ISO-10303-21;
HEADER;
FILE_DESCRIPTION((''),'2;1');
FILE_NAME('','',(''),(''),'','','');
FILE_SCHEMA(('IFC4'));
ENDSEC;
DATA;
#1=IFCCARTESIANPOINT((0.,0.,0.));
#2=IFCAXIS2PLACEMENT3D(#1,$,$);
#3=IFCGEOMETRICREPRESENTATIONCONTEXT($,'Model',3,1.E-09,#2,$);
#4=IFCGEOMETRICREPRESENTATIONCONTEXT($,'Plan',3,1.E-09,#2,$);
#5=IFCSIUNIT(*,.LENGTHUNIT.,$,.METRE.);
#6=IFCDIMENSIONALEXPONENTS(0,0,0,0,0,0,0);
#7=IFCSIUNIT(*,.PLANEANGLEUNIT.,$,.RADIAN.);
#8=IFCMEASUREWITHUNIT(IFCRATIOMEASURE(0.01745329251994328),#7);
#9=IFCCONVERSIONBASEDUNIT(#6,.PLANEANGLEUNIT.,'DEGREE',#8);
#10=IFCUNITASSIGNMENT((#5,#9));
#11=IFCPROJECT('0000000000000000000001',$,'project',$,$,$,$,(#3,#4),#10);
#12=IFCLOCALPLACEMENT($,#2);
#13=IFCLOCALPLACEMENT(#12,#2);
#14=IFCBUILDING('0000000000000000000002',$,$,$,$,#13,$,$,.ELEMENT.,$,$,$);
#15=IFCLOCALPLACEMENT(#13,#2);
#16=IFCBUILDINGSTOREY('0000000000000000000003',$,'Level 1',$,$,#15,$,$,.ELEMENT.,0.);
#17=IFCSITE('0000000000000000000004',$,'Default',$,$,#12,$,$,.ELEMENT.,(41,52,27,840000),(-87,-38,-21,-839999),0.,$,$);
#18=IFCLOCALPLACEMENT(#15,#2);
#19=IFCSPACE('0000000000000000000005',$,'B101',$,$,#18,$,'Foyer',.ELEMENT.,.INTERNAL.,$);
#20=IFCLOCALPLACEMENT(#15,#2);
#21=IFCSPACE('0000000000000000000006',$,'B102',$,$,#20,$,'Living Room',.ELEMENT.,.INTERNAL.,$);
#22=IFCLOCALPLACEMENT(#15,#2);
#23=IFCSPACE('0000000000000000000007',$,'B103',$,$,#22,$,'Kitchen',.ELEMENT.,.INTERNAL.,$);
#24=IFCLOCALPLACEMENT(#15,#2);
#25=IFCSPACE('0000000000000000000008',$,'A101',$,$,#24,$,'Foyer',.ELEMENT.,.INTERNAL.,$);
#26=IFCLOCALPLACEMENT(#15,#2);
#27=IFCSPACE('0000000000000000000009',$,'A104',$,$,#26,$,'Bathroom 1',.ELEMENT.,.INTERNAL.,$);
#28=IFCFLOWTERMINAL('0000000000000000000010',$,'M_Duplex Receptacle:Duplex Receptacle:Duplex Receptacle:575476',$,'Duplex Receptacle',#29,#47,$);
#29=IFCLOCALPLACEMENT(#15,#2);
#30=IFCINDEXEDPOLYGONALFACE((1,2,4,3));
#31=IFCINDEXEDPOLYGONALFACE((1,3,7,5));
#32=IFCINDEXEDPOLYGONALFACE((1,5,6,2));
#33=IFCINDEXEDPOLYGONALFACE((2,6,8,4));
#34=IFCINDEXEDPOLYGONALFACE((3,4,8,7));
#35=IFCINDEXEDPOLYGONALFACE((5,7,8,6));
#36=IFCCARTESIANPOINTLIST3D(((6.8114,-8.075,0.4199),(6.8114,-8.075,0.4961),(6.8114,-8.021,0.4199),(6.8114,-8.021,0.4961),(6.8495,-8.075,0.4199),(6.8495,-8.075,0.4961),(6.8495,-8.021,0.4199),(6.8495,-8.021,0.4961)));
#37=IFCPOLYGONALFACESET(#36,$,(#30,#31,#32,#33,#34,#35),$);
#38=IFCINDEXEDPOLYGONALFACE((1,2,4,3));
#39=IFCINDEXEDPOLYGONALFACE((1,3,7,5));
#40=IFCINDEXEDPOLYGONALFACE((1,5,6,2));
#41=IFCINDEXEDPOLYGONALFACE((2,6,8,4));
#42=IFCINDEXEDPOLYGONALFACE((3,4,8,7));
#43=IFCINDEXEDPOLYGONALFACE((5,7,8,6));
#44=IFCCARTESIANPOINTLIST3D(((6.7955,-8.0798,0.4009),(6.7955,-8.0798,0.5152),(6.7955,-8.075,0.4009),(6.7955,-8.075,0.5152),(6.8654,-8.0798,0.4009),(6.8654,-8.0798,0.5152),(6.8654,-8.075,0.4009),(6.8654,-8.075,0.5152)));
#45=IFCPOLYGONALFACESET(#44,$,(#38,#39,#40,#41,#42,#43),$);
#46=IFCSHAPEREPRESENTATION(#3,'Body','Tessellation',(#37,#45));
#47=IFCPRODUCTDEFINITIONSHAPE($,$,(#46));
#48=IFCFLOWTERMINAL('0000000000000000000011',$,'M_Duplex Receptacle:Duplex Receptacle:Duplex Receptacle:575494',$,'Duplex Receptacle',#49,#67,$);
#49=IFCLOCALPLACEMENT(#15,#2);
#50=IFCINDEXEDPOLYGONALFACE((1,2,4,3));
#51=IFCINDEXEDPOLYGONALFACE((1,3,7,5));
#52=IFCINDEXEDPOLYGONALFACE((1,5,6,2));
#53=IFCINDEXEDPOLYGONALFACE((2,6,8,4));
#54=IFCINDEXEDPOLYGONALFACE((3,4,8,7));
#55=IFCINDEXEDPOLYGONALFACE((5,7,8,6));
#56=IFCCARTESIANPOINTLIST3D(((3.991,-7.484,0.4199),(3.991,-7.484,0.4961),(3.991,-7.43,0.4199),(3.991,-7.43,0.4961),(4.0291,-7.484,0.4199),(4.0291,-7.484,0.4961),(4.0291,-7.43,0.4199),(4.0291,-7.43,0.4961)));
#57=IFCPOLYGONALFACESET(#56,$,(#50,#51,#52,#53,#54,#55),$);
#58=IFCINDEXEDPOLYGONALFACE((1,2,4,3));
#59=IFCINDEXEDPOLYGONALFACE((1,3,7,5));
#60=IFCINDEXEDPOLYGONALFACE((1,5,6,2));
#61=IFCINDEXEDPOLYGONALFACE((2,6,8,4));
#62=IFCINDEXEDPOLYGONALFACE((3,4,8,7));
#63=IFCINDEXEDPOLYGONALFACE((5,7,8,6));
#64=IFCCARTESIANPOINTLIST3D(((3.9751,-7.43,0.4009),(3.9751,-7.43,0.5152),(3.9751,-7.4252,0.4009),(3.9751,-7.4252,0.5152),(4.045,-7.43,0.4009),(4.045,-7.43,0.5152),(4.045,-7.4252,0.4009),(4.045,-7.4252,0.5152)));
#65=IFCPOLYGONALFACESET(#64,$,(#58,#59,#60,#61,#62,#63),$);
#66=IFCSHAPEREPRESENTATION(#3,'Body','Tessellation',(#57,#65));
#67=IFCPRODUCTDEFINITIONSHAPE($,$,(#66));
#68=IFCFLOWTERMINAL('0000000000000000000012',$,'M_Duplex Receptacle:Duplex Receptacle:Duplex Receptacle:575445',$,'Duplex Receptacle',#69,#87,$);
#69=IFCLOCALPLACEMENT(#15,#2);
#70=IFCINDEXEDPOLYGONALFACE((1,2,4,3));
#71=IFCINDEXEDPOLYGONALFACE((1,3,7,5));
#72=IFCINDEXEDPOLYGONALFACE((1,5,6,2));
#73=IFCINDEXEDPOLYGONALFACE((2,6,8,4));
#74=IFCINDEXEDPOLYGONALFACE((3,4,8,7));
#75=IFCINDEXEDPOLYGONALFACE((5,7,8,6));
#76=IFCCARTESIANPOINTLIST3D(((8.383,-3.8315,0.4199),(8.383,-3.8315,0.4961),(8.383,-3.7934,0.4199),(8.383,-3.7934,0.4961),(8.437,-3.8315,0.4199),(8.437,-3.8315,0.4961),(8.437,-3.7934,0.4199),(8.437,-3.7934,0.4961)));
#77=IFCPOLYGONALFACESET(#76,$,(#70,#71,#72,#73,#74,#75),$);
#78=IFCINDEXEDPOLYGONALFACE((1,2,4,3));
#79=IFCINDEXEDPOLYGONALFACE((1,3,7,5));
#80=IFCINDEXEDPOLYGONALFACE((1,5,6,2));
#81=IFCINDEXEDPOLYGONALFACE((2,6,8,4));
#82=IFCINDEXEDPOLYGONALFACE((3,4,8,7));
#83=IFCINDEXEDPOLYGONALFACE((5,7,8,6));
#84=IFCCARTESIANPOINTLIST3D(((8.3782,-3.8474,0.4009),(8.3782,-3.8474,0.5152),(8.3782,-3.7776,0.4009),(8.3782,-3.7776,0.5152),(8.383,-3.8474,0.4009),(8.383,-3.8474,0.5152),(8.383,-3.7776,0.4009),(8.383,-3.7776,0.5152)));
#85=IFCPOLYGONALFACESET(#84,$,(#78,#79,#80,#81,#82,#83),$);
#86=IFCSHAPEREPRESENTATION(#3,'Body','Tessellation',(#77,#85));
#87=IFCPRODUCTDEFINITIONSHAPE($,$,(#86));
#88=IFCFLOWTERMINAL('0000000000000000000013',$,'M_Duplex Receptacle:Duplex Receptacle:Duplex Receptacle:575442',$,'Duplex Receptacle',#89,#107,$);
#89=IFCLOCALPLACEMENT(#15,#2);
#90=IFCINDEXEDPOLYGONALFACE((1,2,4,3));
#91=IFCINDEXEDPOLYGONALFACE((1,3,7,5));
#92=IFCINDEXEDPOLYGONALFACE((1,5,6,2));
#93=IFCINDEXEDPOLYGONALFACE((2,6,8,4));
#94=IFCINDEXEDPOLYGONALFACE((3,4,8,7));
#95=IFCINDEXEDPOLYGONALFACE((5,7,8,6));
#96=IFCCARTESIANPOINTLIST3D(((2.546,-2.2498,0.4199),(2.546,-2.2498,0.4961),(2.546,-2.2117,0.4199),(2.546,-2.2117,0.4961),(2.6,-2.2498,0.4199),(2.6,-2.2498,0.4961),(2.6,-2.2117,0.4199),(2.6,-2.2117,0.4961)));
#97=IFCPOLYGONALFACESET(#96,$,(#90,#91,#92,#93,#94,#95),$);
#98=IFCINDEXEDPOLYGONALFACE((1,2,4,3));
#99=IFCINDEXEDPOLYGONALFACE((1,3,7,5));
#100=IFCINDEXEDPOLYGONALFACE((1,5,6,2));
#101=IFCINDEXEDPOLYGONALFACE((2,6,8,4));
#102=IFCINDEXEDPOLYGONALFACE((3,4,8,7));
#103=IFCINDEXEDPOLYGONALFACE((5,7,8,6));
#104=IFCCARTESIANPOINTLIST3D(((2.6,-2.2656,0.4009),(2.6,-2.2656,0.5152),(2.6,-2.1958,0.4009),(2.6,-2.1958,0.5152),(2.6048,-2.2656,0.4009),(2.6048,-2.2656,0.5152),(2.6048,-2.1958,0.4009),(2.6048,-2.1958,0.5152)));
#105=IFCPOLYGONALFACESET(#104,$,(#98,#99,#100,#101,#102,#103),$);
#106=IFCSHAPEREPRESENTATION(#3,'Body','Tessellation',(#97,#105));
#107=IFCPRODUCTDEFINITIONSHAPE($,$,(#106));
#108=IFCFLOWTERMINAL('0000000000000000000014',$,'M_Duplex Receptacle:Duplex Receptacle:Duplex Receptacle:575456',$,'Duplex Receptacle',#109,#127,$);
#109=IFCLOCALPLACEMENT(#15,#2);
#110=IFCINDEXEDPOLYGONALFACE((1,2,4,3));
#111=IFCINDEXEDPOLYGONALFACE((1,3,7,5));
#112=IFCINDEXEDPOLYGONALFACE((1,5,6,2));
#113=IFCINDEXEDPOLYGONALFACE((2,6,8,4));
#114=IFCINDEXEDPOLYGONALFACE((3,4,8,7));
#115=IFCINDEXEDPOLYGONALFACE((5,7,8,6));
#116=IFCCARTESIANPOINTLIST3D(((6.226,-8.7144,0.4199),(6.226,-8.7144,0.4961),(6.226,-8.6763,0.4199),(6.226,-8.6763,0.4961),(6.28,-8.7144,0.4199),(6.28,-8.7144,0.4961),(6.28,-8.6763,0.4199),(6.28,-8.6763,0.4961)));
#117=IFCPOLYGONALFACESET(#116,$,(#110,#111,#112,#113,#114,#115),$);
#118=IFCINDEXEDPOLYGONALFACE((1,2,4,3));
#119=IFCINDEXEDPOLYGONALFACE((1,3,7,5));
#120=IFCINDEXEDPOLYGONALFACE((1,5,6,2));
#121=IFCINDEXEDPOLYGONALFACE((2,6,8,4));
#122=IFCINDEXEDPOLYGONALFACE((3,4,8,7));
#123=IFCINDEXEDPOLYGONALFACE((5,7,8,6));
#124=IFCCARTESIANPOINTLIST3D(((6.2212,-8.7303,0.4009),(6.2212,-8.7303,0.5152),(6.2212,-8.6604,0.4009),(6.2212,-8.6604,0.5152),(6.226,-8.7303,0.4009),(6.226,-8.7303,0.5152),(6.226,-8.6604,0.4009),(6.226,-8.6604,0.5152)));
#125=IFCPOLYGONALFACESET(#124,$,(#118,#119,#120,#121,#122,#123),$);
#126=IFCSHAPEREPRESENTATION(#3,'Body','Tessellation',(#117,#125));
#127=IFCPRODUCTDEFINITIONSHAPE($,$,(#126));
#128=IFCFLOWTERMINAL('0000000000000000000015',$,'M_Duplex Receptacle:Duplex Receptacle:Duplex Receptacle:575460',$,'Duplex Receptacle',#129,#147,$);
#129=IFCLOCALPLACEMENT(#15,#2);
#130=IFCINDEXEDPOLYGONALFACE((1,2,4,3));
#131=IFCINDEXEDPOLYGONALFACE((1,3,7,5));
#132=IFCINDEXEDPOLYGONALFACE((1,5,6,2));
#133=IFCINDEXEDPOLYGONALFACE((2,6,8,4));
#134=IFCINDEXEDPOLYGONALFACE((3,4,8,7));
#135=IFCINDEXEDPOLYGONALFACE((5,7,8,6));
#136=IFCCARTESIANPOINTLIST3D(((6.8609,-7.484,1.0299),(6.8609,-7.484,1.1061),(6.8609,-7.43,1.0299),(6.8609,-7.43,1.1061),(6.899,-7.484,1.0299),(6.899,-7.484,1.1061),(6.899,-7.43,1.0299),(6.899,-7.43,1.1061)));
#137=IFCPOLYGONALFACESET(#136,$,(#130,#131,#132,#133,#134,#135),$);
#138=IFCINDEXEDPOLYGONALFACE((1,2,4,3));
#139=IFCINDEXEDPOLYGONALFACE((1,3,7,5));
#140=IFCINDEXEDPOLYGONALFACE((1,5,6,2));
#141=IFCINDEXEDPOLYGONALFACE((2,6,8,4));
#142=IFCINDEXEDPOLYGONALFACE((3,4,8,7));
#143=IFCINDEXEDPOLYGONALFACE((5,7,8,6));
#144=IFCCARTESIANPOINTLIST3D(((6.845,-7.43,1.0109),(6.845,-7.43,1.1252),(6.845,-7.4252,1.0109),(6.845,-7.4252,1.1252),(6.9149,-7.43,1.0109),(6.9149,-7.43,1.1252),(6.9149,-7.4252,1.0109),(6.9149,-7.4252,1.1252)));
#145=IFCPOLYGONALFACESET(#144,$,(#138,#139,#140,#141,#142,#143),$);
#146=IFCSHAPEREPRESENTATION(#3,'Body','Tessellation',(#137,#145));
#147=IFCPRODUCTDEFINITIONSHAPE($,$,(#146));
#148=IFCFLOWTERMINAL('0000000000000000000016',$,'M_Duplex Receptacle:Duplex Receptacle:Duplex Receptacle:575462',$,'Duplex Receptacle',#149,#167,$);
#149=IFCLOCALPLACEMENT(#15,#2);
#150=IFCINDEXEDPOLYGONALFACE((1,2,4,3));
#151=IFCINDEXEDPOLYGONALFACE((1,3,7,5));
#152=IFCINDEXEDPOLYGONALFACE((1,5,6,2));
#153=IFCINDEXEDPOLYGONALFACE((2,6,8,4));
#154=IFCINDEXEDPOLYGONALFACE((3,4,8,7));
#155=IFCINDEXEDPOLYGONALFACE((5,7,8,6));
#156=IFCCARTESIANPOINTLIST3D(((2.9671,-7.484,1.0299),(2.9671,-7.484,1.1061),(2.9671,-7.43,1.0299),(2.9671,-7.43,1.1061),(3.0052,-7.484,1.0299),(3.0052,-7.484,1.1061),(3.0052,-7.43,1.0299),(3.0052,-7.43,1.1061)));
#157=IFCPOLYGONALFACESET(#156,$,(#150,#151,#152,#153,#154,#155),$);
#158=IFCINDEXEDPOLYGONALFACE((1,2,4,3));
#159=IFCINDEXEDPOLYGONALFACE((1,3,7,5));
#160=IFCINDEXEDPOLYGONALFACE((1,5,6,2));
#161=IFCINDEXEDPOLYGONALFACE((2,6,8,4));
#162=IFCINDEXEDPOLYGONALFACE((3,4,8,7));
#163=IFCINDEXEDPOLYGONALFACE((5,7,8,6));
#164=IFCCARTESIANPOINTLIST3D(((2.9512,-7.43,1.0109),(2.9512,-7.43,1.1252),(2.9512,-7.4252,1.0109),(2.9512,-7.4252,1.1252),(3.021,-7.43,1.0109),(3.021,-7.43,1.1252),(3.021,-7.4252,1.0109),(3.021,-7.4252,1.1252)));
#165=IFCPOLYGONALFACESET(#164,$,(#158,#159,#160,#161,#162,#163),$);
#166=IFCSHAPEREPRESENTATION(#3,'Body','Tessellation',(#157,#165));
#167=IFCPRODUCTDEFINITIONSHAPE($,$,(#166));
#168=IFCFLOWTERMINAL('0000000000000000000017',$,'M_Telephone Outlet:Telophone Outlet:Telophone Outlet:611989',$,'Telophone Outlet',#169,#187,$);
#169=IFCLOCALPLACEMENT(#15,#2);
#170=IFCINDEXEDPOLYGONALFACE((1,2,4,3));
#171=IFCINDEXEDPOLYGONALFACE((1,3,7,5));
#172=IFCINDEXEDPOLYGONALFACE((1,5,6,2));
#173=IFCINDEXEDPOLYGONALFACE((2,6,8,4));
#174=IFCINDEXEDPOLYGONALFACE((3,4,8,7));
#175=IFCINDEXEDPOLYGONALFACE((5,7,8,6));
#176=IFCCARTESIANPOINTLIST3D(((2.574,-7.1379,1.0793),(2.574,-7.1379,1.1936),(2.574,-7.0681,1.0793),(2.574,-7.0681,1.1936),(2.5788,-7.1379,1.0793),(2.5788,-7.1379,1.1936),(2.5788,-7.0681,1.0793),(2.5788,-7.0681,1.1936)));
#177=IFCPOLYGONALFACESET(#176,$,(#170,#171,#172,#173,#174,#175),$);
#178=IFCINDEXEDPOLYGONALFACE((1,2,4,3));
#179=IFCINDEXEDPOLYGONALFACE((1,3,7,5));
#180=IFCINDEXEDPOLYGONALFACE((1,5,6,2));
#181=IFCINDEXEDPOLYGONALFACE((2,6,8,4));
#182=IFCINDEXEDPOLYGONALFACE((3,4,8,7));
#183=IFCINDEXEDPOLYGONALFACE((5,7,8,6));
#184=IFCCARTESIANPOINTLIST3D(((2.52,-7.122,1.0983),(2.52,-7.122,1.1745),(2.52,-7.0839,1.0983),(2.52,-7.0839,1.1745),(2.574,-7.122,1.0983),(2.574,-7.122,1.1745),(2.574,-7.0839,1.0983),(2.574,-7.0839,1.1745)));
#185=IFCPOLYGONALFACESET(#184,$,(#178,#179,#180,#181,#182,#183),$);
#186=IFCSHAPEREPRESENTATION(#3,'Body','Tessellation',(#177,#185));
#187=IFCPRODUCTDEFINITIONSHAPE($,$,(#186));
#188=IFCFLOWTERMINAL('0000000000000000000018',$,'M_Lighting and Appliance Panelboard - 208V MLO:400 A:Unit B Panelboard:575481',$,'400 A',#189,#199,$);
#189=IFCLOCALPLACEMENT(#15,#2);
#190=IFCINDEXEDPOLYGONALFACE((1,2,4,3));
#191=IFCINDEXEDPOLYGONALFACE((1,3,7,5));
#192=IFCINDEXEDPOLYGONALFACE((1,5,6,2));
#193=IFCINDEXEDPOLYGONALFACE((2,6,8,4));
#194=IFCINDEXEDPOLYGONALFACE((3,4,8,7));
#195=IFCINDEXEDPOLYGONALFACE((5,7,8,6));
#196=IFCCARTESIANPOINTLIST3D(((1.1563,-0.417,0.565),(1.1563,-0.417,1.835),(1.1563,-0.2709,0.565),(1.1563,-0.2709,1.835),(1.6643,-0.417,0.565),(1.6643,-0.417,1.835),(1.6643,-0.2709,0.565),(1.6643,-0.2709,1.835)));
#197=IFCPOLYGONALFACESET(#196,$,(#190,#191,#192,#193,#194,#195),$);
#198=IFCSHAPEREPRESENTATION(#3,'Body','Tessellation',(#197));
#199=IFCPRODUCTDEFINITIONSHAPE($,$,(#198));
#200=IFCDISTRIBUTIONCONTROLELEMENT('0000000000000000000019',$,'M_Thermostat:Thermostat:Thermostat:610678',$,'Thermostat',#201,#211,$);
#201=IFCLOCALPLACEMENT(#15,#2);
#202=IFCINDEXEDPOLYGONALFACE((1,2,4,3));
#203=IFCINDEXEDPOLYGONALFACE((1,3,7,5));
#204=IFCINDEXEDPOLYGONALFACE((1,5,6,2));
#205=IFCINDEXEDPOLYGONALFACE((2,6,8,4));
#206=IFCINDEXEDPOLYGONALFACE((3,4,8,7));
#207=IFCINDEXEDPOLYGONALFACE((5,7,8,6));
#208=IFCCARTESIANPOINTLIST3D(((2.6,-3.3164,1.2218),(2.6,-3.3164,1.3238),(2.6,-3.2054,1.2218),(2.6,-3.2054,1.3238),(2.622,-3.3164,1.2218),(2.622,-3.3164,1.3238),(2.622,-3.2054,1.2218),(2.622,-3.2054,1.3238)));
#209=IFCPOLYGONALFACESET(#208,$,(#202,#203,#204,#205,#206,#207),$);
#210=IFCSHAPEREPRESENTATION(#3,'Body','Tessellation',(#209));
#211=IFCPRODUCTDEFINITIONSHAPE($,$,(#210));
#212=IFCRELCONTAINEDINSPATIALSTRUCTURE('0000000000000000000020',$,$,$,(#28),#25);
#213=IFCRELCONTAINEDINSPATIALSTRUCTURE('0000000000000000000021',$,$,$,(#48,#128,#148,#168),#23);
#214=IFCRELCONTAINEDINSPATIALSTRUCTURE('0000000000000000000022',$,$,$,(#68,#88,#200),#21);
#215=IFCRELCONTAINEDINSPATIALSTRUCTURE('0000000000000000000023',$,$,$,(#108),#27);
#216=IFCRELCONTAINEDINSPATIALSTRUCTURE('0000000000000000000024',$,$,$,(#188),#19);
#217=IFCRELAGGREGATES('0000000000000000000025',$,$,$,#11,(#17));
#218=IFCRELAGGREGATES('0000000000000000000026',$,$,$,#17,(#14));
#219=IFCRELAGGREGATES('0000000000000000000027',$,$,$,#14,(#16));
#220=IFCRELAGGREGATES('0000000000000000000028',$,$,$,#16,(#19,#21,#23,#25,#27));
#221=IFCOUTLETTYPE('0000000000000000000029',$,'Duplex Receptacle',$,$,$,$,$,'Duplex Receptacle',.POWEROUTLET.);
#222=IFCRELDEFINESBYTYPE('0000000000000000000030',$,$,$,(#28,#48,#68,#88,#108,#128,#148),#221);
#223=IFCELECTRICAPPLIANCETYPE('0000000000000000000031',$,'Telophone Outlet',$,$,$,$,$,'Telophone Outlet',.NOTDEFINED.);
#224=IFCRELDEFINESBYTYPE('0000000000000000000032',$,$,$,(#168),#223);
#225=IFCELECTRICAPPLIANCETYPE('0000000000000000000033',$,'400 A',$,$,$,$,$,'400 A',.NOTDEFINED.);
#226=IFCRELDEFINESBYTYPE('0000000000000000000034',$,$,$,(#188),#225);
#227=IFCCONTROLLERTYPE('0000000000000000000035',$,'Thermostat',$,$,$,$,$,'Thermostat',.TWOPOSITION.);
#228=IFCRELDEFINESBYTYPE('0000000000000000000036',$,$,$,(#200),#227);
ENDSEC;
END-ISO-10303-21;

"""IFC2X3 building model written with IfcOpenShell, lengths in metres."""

from ifc_helpers import new_model, entity, si_unit, converted_unit, frame, origin, origin_2d_with_axis, place, context, project, spatial, rectangle, extrude, source, transform, mapped, type_object, type_shapes, element, save


model = new_model("IFC2X3")

# Units and contexts
model_context = context("Model", 3, precision=1e-09, world=origin())
plan_context = context("Plan", 3, precision=1e-09, world=origin())
ifc_project = project(units=[si_unit("LENGTHUNIT", "METRE"), converted_unit("PLANEANGLEUNIT", "DEGREE", entity("IfcRatioMeasure", 0.01745329251994328), si_unit("PLANEANGLEUNIT", "RADIAN"), dimensions=[0, 0, 0, 0, 0, 0, 0])], contexts=[model_context, plan_context])

# Site, building, storey, space
site_placement = place(None, origin())
site = spatial("IfcSite", under=ifc_project, at=site_placement, Name="Default", CompositionType="ELEMENT", RefLatitude=(41, 52, 27, 840000), RefLongitude=(-87, -38, -21, -839999), RefElevation=0.0)
building_placement = place(site_placement, origin())
building = spatial("IfcBuilding", under=site, at=building_placement, CompositionType="ELEMENT")
storey_placement = place(building_placement, origin())
storey = spatial("IfcBuildingStorey", under=building, at=storey_placement, Name="Level 1", CompositionType="ELEMENT", Elevation=0.0)
space_1_placement = place(storey_placement, origin())
space_1 = spatial("IfcSpace", under=storey, at=space_1_placement, Name="B101", LongName="Foyer", CompositionType="ELEMENT", InteriorOrExteriorSpace="INTERNAL")

# Shared definitions
shared_shape_1 = source(origin(), model_context, "Body", "SweptSolid", [
    extrude(rectangle(XDim=0.0381, YDim=0.0762, at=origin_2d_with_axis()), frame((0.0, 0.0, -0.054), z_axis=(0.0, 0.0, 1.0), x_axis=(-1.0, 0.0, 0.0)), (0.0, 0.0, 1.0), 0.054),
    extrude(rectangle(XDim=0.0698, YDim=0.1143, at=origin_2d_with_axis()), frame((0.0, 0.0, 0.0), z_axis=(0.0, 0.0, 1.0), x_axis=(-1.0, 0.0, 0.0)), (0.0, 0.0, 1.0), 0.0048),
])

# Shared definitions
space_2_placement = place(storey_placement, origin())
space_2 = spatial("IfcSpace", under=storey, at=space_2_placement, Name="B102", LongName="Living Room", CompositionType="ELEMENT", InteriorOrExteriorSpace="INTERNAL")

# Shared definitions
space_3_placement = place(storey_placement, origin())
space_3 = spatial("IfcSpace", under=storey, at=space_3_placement, Name="B103", LongName="Kitchen", CompositionType="ELEMENT", InteriorOrExteriorSpace="INTERNAL")

# Shared definitions
outlet_type = type_object("IfcOutletType", Name="Duplex Receptacle", ElementType="Duplex Receptacle", PredefinedType="POWEROUTLET")
type_shapes(outlet_type, [shared_shape_1])

# Shared definitions
space_4_placement = place(storey_placement, origin())
space_4 = spatial("IfcSpace", under=storey, at=space_4_placement, Name="A101", LongName="Foyer", CompositionType="ELEMENT", InteriorOrExteriorSpace="INTERNAL")

# Flow terminals
flow_terminal_1_placement = place(space_4_placement, frame((6.8305, -8.075, 0.458), z_axis=(0.0, -1.0, 0.0), x_axis=(1.0, 0.0, 0.0)))
element("IfcFlowTerminal", 1, at=flow_terminal_1_placement, inside=space_4, type_object=outlet_type, Name="M_Duplex Receptacle:Duplex Receptacle:Duplex Receptacle:575476", ObjectType="Duplex Receptacle", context=model_context, shape_type="MappedRepresentation", body=[
    mapped(shared_shape_1, transform((0.0, 0.0, 0.0), scale=1.0)),
])
flow_terminal_2_placement = place(space_3_placement, frame((4.0101, -7.43, 0.458), z_axis=(0.0, 1.0, 0.0), x_axis=(-1.0, 0.0, 0.0)))
element("IfcFlowTerminal", 2, at=flow_terminal_2_placement, inside=space_3, type_object=outlet_type, Name="M_Duplex Receptacle:Duplex Receptacle:Duplex Receptacle:575494", ObjectType="Duplex Receptacle", context=model_context, shape_type="MappedRepresentation", body=[
    mapped(shared_shape_1, transform((0.0, 0.0, 0.0), scale=1.0)),
])
for number, where, z_axis, x_axis, name in (
    (3, (8.383, -3.8125, 0.458), (-1.0, 0.0, 0.0), (0.0, -1.0, 0.0), "M_Duplex Receptacle:Duplex Receptacle:Duplex Receptacle:575445"),
    (4, (2.6, -2.2307, 0.458), (1.0, 0.0, 0.0), (0.0, 1.0, 0.0), "M_Duplex Receptacle:Duplex Receptacle:Duplex Receptacle:575442"),
):
    element("IfcFlowTerminal", number, at=place(space_2_placement, frame(where, z_axis=z_axis, x_axis=x_axis)), inside=space_2, type_object=outlet_type, Name=name, ObjectType="Duplex Receptacle", context=model_context, shape_type="MappedRepresentation", body=[
        mapped(shared_shape_1, transform((0.0, 0.0, 0.0), scale=1.0)),
    ])

# Shared definitions
space_5_placement = place(storey_placement, origin())
space_5 = spatial("IfcSpace", under=storey, at=space_5_placement, Name="A104", LongName="Bathroom 1", CompositionType="ELEMENT", InteriorOrExteriorSpace="INTERNAL")

# Flow terminals
flow_terminal_3_placement = place(space_5_placement, frame((6.226, -8.6953, 0.458), z_axis=(-1.0, 0.0, 0.0), x_axis=(0.0, -1.0, 0.0)))
element("IfcFlowTerminal", 5, at=flow_terminal_3_placement, inside=space_5, type_object=outlet_type, Name="M_Duplex Receptacle:Duplex Receptacle:Duplex Receptacle:575456", ObjectType="Duplex Receptacle", context=model_context, shape_type="MappedRepresentation", body=[
    mapped(shared_shape_1, transform((0.0, 0.0, 0.0), scale=1.0)),
])
for number, where, z_axis, x_axis, name in (
    (6, (6.88, -7.43, 1.068), (0.0, 1.0, 0.0), (-1.0, 0.0, 0.0), "M_Duplex Receptacle:Duplex Receptacle:Duplex Receptacle:575460"),
    (7, (2.9861, -7.43, 1.068), (0.0, 1.0, 0.0), (-1.0, 0.0, 0.0), "M_Duplex Receptacle:Duplex Receptacle:Duplex Receptacle:575462"),
):
    element("IfcFlowTerminal", number, at=place(space_3_placement, frame(where, z_axis=z_axis, x_axis=x_axis)), inside=space_3, type_object=outlet_type, Name=name, ObjectType="Duplex Receptacle", context=model_context, shape_type="MappedRepresentation", body=[
        mapped(shared_shape_1, transform((0.0, 0.0, 0.0), scale=1.0)),
    ])
electric_appliance_type_1 = type_object("IfcElectricApplianceType", Name="Telophone Outlet", ElementType="Telophone Outlet", PredefinedType="NOTDEFINED")
shared_shape_2 = source(origin(), model_context, "Body", "SweptSolid", [
    extrude(rectangle(XDim=0.0699, YDim=0.1143, at=origin_2d_with_axis()), frame((0.0, 0.0, 0.0), z_axis=(0.0, 0.0, 1.0), x_axis=(-1.0, 0.0, 0.0)), (0.0, 0.0, 1.0), 0.0048),
    extrude(rectangle(XDim=0.0381, YDim=0.0762, at=origin_2d_with_axis()), frame((0.0, 0.0, -0.054), z_axis=(0.0, 0.0, 1.0), x_axis=(-1.0, 0.0, 0.0)), (0.0, 0.0, 1.0), 0.054),
])
type_shapes(electric_appliance_type_1, [shared_shape_2])
flow_terminal_4_placement = place(space_3_placement, frame((2.574, -7.103, 1.1364), z_axis=(1.0, 0.0, 0.0), x_axis=(0.0, 1.0, 0.0)))
element("IfcFlowTerminal", 8, at=flow_terminal_4_placement, inside=space_3, type_object=electric_appliance_type_1, Name="M_Telephone Outlet:Telophone Outlet:Telophone Outlet:611989", ObjectType="Telophone Outlet", context=model_context, shape_type="MappedRepresentation", body=[
    mapped(shared_shape_2, transform((0.0, 0.0, 0.0), scale=1.0)),
])
electric_appliance_type_2 = type_object("IfcElectricApplianceType", Name="400 A", ElementType="400 A", PredefinedType="NOTDEFINED")
shared_shape_3 = source(origin(), model_context, "Body", "SweptSolid", [
    extrude(rectangle(XDim=0.508, YDim=1.27, at=origin_2d_with_axis()), frame((0.0, -0.4191, -0.1461), z_axis=(0.0, 0.0, 1.0), x_axis=(-1.0, 0.0, 0.0)), (0.0, 0.0, 1.0), 0.1461),
])
type_shapes(electric_appliance_type_2, [shared_shape_3])
flow_terminal_5_placement = place(space_1_placement, frame((1.4103, -0.417, 1.6191), z_axis=(0.0, -1.0, 0.0), x_axis=(1.0, 0.0, 0.0)))
element("IfcFlowTerminal", 9, at=flow_terminal_5_placement, inside=space_1, type_object=electric_appliance_type_2, Name="M_Lighting and Appliance Panelboard - 208V MLO:400 A:Unit B Panelboard:575481", ObjectType="400 A", context=model_context, shape_type="MappedRepresentation", body=[
    mapped(shared_shape_3, transform((0.0, 0.0, 0.0), scale=1.0)),
])

# Distribution control element
controller_type = type_object("IfcControllerType", Name="Thermostat", ElementType="Thermostat", PredefinedType="TWOPOSITION")
shared_shape_4 = source(origin(), model_context, "Body", "SweptSolid", [
    extrude(rectangle(XDim=0.102, YDim=0.111, at=origin_2d_with_axis()), frame((0.0, -0.051, 0.0), z_axis=(0.0, 0.0, 1.0), x_axis=(0.0, 1.0, 0.0)), (0.0, 0.0, 1.0), 0.022),
])
type_shapes(controller_type, [shared_shape_4])
distribution_control_element_placement = place(space_2_placement, frame((2.6, -3.2609, 1.3238), z_axis=(1.0, 0.0, 0.0), x_axis=(0.0, 1.0, 0.0)))
element("IfcDistributionControlElement", 10, at=distribution_control_element_placement, inside=space_2, type_object=controller_type, Name="M_Thermostat:Thermostat:Thermostat:610678", ObjectType="Thermostat", context=model_context, shape_type="MappedRepresentation", body=[
    mapped(shared_shape_4, transform((0.0, 0.0, 0.0), scale=1.0)),
])

save(model, "model.ifc")
